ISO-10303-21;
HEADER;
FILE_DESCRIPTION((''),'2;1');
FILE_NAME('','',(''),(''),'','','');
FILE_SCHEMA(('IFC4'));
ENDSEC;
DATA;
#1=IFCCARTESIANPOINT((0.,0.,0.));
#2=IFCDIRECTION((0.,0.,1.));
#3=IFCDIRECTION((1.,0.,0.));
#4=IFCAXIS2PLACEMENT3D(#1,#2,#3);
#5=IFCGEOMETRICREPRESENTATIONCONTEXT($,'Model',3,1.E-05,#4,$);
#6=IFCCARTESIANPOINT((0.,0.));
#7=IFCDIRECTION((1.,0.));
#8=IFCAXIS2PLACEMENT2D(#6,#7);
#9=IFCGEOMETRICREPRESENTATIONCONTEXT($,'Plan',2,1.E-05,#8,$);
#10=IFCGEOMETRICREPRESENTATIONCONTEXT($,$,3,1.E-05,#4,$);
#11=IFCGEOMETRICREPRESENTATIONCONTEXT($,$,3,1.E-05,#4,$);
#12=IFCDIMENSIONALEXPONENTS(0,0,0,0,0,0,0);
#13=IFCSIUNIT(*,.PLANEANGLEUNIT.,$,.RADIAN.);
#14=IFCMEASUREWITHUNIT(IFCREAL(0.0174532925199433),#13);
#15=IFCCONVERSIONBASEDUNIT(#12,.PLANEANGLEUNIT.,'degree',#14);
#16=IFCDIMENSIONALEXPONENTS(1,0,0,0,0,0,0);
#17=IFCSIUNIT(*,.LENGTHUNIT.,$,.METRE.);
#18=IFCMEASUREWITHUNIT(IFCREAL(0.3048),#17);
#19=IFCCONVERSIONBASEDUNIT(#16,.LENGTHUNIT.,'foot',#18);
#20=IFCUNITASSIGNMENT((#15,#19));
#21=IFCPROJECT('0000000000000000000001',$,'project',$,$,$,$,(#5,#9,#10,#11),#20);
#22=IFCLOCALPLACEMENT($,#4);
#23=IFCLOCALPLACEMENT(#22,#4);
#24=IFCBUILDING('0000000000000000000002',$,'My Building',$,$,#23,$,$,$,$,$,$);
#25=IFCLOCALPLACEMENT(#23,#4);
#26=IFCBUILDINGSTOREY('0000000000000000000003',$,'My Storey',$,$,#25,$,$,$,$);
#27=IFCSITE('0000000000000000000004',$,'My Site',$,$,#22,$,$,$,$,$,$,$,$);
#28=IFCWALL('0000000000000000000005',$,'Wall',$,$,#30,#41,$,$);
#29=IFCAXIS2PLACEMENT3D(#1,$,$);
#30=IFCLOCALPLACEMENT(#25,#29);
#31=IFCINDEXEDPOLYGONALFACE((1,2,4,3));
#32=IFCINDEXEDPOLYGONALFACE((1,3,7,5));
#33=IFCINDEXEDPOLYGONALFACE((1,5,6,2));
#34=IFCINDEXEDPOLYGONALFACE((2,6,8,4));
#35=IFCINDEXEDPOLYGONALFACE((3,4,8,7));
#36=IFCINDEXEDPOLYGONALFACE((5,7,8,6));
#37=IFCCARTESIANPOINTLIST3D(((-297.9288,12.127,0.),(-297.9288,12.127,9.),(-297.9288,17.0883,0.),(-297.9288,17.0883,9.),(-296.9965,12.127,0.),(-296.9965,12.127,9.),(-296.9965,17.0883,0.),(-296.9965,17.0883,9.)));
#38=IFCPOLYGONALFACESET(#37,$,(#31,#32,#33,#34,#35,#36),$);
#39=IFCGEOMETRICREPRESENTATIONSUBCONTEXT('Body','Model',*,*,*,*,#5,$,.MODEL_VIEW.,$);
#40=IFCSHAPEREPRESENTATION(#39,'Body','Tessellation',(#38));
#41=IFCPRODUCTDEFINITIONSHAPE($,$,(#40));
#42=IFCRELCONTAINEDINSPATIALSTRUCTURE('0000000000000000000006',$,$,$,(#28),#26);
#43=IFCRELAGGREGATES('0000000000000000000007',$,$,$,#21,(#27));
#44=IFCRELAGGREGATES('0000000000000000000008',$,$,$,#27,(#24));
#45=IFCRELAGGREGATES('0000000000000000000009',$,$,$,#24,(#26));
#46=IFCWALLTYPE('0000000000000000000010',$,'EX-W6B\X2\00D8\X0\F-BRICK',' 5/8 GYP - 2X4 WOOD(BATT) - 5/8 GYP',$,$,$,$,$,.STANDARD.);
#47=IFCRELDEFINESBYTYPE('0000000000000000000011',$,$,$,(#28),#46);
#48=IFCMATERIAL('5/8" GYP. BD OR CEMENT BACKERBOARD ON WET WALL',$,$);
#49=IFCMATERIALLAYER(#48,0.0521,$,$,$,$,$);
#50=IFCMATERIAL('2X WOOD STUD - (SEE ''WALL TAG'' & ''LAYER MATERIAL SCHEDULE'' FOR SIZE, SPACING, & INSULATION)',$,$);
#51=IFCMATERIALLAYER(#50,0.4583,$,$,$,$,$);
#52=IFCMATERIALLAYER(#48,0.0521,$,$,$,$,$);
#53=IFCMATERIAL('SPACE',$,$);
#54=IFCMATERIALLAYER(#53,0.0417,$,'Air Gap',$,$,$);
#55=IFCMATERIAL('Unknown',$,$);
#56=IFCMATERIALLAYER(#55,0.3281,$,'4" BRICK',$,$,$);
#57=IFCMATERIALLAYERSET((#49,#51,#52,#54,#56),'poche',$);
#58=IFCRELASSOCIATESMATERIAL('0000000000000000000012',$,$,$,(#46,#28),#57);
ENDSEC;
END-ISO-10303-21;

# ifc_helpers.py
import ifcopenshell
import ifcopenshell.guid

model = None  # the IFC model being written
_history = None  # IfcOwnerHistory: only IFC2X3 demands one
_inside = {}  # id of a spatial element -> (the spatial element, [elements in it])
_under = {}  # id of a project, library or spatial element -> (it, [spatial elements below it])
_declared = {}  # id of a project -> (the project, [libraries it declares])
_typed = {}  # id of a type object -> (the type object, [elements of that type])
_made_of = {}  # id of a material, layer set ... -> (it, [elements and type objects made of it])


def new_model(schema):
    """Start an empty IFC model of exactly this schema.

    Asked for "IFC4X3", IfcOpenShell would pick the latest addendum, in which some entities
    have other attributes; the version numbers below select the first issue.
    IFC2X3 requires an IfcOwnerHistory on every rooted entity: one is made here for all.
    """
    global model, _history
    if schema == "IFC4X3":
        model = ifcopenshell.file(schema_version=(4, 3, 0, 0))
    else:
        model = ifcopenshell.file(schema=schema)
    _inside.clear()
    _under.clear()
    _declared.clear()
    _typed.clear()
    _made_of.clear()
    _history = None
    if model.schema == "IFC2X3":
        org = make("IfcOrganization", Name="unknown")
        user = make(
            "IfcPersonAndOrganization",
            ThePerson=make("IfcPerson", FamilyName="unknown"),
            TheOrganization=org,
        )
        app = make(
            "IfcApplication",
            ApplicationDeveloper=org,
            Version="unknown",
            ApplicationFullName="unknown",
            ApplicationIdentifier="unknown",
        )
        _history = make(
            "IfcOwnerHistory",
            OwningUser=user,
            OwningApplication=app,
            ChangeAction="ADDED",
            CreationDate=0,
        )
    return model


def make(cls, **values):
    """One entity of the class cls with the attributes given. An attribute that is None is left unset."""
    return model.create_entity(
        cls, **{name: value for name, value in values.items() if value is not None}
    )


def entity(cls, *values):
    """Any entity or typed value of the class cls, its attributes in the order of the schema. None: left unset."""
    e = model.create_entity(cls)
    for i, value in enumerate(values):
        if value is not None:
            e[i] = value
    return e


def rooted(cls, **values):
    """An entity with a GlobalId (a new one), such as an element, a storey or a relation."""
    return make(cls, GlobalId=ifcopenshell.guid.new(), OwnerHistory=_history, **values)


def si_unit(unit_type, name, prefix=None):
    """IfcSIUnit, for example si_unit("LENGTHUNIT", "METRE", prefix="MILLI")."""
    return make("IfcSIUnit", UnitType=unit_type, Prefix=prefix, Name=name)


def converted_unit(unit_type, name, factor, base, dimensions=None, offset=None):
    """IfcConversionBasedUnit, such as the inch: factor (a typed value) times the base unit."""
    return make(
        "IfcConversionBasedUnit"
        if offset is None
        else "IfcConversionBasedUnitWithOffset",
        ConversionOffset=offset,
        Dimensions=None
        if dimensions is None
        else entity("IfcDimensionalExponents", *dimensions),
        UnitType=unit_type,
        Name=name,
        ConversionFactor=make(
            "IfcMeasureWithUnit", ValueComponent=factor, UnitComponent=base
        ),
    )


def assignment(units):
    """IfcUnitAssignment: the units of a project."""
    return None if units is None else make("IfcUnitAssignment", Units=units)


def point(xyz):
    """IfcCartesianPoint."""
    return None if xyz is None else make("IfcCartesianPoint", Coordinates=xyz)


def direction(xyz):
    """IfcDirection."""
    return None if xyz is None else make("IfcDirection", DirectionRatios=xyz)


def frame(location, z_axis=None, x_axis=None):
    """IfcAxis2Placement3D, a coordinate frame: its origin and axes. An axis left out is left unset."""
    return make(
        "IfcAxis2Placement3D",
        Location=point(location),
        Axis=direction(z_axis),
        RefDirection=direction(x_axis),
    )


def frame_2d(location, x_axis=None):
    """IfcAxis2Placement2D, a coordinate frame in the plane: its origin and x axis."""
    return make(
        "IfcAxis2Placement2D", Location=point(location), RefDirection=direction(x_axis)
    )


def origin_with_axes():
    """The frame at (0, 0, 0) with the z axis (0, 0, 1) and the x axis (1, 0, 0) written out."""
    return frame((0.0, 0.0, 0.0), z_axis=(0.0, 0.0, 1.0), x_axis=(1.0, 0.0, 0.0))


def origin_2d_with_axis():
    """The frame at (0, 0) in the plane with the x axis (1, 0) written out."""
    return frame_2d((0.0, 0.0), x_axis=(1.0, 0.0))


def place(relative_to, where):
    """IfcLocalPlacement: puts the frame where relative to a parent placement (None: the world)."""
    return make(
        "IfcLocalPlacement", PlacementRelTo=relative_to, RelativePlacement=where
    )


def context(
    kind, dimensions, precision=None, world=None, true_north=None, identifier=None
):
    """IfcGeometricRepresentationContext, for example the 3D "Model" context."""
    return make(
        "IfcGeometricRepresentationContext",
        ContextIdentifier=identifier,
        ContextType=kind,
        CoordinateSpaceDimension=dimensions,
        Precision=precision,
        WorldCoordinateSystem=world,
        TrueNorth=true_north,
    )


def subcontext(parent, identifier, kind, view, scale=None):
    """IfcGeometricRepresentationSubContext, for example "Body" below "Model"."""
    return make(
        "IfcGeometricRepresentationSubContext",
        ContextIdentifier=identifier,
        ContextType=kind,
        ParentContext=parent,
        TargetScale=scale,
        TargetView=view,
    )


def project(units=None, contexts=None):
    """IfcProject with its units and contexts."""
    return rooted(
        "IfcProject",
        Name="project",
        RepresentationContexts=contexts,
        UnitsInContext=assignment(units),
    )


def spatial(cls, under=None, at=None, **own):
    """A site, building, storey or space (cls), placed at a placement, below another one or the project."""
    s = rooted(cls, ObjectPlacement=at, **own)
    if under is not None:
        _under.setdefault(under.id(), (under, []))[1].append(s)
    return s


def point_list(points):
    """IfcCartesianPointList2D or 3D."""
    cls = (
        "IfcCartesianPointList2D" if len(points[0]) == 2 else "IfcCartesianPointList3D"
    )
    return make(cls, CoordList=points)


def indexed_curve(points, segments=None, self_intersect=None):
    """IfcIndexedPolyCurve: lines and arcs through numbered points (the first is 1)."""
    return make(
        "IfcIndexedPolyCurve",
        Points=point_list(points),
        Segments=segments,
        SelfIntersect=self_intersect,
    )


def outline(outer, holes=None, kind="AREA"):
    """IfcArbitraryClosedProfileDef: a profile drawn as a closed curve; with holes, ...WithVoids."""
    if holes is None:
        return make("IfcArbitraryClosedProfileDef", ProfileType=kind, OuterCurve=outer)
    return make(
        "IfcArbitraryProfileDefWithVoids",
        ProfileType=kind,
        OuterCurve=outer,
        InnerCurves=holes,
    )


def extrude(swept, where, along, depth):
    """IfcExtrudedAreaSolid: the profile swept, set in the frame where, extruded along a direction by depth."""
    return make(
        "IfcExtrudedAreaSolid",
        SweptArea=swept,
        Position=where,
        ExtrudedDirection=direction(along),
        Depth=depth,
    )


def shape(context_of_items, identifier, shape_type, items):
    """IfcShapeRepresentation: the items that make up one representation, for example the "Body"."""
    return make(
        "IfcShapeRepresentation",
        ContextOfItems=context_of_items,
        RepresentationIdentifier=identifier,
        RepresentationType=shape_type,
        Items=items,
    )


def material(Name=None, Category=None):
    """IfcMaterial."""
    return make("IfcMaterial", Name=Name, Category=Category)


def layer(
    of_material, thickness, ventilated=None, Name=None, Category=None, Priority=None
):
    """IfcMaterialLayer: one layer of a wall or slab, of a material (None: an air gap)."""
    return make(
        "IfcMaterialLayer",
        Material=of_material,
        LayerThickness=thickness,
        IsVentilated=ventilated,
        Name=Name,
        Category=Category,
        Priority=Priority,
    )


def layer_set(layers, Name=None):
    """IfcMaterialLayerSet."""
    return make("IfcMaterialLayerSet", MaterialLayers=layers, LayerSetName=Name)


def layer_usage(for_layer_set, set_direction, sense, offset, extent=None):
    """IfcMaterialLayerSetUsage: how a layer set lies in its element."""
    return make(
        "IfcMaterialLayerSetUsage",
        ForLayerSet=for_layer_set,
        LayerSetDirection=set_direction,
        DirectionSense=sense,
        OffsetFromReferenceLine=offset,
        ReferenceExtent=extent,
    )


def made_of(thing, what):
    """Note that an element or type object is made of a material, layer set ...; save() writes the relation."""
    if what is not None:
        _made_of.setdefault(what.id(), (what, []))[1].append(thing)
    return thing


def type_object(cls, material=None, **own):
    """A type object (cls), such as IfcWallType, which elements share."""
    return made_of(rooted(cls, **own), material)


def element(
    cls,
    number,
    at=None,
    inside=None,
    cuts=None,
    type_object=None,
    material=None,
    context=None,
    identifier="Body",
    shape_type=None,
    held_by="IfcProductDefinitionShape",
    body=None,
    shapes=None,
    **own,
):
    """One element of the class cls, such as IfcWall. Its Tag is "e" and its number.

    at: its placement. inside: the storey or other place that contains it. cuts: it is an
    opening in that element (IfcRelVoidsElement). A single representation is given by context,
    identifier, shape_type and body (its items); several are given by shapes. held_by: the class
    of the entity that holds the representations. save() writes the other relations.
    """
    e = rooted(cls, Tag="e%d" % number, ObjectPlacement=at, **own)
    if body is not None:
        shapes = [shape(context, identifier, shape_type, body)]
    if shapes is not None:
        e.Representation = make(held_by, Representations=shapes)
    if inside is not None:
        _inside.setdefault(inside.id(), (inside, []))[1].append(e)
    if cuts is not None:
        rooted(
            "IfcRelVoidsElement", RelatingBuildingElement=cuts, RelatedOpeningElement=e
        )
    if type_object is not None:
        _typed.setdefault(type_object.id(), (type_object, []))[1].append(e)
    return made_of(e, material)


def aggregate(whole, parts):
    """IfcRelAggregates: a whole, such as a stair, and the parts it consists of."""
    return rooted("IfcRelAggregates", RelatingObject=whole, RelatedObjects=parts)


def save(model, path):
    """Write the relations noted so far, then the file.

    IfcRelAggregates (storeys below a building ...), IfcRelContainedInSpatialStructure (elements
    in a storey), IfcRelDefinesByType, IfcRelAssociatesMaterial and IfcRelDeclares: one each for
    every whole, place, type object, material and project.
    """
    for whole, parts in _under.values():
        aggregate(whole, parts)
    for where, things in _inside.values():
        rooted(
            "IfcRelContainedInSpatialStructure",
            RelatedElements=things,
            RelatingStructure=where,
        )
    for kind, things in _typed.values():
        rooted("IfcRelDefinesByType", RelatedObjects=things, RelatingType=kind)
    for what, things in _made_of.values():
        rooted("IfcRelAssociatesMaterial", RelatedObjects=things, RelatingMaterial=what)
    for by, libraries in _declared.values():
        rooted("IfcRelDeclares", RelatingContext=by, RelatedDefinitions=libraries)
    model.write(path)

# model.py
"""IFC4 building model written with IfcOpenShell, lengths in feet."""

from ifc_helpers import new_model, entity, si_unit, converted_unit, frame, origin_with_axes, origin_2d_with_axis, place, context, subcontext, project, spatial, indexed_curve, outline, extrude, material, layer, layer_set, layer_usage, type_object, element, save


model = new_model("IFC4")

# Units and contexts
model_context = context("Model", 3, precision=1e-05, world=origin_with_axes())
plan_context = context("Plan", 2, precision=1e-05, world=origin_2d_with_axis())
context_of_model_1 = context(None, 3, precision=1e-05, world=origin_with_axes())
context_of_model_2 = context(None, 3, precision=1e-05, world=origin_with_axes())
body_context_1 = subcontext(model_context, "Body", "Model", "MODEL_VIEW")
ifc_project = project(units=[converted_unit("PLANEANGLEUNIT", "degree", entity("IfcReal", 0.0174532925199433), si_unit("PLANEANGLEUNIT", "RADIAN"), dimensions=[0, 0, 0, 0, 0, 0, 0]), converted_unit("LENGTHUNIT", "foot", entity("IfcReal", 0.3048), si_unit("LENGTHUNIT", "METRE"), dimensions=[1, 0, 0, 0, 0, 0, 0])], contexts=[model_context, plan_context, context_of_model_1, context_of_model_2])

# Site, building, storey
site_placement = place(None, origin_with_axes())
site = spatial("IfcSite", under=ifc_project, at=site_placement, Name="My Site")
building_placement = place(site_placement, origin_with_axes())
building = spatial("IfcBuilding", under=site, at=building_placement, Name="My Building")
storey_placement = place(building_placement, origin_with_axes())
storey = spatial("IfcBuildingStorey", under=building, at=storey_placement, Name="My Storey")

# Shared definitions
ifc_material_1 = material(Name="5/8\" GYP. BD OR CEMENT BACKERBOARD ON WET WALL")
ifc_material_2 = material(Name="2X WOOD STUD - (SEE 'WALL TAG' & 'LAYER MATERIAL SCHEDULE' FOR SIZE, SPACING, & INSULATION)")

# Wall
ifc_layer_1 = layer(ifc_material_1, 0.0521)
ifc_layer_2 = layer(ifc_material_2, 0.4583)
ifc_layer_3 = layer(ifc_material_1, 0.0521)
ifc_material_3 = material(Name="SPACE")
ifc_layer_4 = layer(ifc_material_3, 0.0417, Name="Air Gap")
ifc_material_4 = material(Name="Unknown")
ifc_layer_5 = layer(ifc_material_4, 0.3281, Name="4\" BRICK")
ifc_layer_set_1 = layer_set([ifc_layer_1, ifc_layer_2, ifc_layer_3, ifc_layer_4, ifc_layer_5], Name="poche")
ifc_layer_usage_1 = layer_usage(ifc_layer_set_1, "AXIS2", "POSITIVE", 0.0)
wall_type_1 = type_object("IfcWallType", Name="EX-W6BØF-BRICK", Description=" 5/8 GYP - 2X4 WOOD(BATT) - 5/8 GYP", PredefinedType="STANDARD", material=ifc_layer_set_1)
wall_1_placement = place(storey_placement, frame((-296.9965, 12.127, 0.0), z_axis=(0.0, 0.0, 1.0), x_axis=(0.0, 1.0, 0.0)))
element("IfcWall", 1, at=wall_1_placement, inside=storey, type_object=wall_type_1, material=ifc_layer_usage_1, Name="Wall", context=body_context_1, shape_type="SweptSolid", body=[
    extrude(outline(indexed_curve([(0.0, 0.0), (0.0, 0.9323), (4.9612, 0.9323), (4.9612, 0.0), (0.0, 0.0)], self_intersect=False)), origin_with_axes(), (0.0, 0.0, 1.0), 9.0),
])

save(model, "model.ifc")
